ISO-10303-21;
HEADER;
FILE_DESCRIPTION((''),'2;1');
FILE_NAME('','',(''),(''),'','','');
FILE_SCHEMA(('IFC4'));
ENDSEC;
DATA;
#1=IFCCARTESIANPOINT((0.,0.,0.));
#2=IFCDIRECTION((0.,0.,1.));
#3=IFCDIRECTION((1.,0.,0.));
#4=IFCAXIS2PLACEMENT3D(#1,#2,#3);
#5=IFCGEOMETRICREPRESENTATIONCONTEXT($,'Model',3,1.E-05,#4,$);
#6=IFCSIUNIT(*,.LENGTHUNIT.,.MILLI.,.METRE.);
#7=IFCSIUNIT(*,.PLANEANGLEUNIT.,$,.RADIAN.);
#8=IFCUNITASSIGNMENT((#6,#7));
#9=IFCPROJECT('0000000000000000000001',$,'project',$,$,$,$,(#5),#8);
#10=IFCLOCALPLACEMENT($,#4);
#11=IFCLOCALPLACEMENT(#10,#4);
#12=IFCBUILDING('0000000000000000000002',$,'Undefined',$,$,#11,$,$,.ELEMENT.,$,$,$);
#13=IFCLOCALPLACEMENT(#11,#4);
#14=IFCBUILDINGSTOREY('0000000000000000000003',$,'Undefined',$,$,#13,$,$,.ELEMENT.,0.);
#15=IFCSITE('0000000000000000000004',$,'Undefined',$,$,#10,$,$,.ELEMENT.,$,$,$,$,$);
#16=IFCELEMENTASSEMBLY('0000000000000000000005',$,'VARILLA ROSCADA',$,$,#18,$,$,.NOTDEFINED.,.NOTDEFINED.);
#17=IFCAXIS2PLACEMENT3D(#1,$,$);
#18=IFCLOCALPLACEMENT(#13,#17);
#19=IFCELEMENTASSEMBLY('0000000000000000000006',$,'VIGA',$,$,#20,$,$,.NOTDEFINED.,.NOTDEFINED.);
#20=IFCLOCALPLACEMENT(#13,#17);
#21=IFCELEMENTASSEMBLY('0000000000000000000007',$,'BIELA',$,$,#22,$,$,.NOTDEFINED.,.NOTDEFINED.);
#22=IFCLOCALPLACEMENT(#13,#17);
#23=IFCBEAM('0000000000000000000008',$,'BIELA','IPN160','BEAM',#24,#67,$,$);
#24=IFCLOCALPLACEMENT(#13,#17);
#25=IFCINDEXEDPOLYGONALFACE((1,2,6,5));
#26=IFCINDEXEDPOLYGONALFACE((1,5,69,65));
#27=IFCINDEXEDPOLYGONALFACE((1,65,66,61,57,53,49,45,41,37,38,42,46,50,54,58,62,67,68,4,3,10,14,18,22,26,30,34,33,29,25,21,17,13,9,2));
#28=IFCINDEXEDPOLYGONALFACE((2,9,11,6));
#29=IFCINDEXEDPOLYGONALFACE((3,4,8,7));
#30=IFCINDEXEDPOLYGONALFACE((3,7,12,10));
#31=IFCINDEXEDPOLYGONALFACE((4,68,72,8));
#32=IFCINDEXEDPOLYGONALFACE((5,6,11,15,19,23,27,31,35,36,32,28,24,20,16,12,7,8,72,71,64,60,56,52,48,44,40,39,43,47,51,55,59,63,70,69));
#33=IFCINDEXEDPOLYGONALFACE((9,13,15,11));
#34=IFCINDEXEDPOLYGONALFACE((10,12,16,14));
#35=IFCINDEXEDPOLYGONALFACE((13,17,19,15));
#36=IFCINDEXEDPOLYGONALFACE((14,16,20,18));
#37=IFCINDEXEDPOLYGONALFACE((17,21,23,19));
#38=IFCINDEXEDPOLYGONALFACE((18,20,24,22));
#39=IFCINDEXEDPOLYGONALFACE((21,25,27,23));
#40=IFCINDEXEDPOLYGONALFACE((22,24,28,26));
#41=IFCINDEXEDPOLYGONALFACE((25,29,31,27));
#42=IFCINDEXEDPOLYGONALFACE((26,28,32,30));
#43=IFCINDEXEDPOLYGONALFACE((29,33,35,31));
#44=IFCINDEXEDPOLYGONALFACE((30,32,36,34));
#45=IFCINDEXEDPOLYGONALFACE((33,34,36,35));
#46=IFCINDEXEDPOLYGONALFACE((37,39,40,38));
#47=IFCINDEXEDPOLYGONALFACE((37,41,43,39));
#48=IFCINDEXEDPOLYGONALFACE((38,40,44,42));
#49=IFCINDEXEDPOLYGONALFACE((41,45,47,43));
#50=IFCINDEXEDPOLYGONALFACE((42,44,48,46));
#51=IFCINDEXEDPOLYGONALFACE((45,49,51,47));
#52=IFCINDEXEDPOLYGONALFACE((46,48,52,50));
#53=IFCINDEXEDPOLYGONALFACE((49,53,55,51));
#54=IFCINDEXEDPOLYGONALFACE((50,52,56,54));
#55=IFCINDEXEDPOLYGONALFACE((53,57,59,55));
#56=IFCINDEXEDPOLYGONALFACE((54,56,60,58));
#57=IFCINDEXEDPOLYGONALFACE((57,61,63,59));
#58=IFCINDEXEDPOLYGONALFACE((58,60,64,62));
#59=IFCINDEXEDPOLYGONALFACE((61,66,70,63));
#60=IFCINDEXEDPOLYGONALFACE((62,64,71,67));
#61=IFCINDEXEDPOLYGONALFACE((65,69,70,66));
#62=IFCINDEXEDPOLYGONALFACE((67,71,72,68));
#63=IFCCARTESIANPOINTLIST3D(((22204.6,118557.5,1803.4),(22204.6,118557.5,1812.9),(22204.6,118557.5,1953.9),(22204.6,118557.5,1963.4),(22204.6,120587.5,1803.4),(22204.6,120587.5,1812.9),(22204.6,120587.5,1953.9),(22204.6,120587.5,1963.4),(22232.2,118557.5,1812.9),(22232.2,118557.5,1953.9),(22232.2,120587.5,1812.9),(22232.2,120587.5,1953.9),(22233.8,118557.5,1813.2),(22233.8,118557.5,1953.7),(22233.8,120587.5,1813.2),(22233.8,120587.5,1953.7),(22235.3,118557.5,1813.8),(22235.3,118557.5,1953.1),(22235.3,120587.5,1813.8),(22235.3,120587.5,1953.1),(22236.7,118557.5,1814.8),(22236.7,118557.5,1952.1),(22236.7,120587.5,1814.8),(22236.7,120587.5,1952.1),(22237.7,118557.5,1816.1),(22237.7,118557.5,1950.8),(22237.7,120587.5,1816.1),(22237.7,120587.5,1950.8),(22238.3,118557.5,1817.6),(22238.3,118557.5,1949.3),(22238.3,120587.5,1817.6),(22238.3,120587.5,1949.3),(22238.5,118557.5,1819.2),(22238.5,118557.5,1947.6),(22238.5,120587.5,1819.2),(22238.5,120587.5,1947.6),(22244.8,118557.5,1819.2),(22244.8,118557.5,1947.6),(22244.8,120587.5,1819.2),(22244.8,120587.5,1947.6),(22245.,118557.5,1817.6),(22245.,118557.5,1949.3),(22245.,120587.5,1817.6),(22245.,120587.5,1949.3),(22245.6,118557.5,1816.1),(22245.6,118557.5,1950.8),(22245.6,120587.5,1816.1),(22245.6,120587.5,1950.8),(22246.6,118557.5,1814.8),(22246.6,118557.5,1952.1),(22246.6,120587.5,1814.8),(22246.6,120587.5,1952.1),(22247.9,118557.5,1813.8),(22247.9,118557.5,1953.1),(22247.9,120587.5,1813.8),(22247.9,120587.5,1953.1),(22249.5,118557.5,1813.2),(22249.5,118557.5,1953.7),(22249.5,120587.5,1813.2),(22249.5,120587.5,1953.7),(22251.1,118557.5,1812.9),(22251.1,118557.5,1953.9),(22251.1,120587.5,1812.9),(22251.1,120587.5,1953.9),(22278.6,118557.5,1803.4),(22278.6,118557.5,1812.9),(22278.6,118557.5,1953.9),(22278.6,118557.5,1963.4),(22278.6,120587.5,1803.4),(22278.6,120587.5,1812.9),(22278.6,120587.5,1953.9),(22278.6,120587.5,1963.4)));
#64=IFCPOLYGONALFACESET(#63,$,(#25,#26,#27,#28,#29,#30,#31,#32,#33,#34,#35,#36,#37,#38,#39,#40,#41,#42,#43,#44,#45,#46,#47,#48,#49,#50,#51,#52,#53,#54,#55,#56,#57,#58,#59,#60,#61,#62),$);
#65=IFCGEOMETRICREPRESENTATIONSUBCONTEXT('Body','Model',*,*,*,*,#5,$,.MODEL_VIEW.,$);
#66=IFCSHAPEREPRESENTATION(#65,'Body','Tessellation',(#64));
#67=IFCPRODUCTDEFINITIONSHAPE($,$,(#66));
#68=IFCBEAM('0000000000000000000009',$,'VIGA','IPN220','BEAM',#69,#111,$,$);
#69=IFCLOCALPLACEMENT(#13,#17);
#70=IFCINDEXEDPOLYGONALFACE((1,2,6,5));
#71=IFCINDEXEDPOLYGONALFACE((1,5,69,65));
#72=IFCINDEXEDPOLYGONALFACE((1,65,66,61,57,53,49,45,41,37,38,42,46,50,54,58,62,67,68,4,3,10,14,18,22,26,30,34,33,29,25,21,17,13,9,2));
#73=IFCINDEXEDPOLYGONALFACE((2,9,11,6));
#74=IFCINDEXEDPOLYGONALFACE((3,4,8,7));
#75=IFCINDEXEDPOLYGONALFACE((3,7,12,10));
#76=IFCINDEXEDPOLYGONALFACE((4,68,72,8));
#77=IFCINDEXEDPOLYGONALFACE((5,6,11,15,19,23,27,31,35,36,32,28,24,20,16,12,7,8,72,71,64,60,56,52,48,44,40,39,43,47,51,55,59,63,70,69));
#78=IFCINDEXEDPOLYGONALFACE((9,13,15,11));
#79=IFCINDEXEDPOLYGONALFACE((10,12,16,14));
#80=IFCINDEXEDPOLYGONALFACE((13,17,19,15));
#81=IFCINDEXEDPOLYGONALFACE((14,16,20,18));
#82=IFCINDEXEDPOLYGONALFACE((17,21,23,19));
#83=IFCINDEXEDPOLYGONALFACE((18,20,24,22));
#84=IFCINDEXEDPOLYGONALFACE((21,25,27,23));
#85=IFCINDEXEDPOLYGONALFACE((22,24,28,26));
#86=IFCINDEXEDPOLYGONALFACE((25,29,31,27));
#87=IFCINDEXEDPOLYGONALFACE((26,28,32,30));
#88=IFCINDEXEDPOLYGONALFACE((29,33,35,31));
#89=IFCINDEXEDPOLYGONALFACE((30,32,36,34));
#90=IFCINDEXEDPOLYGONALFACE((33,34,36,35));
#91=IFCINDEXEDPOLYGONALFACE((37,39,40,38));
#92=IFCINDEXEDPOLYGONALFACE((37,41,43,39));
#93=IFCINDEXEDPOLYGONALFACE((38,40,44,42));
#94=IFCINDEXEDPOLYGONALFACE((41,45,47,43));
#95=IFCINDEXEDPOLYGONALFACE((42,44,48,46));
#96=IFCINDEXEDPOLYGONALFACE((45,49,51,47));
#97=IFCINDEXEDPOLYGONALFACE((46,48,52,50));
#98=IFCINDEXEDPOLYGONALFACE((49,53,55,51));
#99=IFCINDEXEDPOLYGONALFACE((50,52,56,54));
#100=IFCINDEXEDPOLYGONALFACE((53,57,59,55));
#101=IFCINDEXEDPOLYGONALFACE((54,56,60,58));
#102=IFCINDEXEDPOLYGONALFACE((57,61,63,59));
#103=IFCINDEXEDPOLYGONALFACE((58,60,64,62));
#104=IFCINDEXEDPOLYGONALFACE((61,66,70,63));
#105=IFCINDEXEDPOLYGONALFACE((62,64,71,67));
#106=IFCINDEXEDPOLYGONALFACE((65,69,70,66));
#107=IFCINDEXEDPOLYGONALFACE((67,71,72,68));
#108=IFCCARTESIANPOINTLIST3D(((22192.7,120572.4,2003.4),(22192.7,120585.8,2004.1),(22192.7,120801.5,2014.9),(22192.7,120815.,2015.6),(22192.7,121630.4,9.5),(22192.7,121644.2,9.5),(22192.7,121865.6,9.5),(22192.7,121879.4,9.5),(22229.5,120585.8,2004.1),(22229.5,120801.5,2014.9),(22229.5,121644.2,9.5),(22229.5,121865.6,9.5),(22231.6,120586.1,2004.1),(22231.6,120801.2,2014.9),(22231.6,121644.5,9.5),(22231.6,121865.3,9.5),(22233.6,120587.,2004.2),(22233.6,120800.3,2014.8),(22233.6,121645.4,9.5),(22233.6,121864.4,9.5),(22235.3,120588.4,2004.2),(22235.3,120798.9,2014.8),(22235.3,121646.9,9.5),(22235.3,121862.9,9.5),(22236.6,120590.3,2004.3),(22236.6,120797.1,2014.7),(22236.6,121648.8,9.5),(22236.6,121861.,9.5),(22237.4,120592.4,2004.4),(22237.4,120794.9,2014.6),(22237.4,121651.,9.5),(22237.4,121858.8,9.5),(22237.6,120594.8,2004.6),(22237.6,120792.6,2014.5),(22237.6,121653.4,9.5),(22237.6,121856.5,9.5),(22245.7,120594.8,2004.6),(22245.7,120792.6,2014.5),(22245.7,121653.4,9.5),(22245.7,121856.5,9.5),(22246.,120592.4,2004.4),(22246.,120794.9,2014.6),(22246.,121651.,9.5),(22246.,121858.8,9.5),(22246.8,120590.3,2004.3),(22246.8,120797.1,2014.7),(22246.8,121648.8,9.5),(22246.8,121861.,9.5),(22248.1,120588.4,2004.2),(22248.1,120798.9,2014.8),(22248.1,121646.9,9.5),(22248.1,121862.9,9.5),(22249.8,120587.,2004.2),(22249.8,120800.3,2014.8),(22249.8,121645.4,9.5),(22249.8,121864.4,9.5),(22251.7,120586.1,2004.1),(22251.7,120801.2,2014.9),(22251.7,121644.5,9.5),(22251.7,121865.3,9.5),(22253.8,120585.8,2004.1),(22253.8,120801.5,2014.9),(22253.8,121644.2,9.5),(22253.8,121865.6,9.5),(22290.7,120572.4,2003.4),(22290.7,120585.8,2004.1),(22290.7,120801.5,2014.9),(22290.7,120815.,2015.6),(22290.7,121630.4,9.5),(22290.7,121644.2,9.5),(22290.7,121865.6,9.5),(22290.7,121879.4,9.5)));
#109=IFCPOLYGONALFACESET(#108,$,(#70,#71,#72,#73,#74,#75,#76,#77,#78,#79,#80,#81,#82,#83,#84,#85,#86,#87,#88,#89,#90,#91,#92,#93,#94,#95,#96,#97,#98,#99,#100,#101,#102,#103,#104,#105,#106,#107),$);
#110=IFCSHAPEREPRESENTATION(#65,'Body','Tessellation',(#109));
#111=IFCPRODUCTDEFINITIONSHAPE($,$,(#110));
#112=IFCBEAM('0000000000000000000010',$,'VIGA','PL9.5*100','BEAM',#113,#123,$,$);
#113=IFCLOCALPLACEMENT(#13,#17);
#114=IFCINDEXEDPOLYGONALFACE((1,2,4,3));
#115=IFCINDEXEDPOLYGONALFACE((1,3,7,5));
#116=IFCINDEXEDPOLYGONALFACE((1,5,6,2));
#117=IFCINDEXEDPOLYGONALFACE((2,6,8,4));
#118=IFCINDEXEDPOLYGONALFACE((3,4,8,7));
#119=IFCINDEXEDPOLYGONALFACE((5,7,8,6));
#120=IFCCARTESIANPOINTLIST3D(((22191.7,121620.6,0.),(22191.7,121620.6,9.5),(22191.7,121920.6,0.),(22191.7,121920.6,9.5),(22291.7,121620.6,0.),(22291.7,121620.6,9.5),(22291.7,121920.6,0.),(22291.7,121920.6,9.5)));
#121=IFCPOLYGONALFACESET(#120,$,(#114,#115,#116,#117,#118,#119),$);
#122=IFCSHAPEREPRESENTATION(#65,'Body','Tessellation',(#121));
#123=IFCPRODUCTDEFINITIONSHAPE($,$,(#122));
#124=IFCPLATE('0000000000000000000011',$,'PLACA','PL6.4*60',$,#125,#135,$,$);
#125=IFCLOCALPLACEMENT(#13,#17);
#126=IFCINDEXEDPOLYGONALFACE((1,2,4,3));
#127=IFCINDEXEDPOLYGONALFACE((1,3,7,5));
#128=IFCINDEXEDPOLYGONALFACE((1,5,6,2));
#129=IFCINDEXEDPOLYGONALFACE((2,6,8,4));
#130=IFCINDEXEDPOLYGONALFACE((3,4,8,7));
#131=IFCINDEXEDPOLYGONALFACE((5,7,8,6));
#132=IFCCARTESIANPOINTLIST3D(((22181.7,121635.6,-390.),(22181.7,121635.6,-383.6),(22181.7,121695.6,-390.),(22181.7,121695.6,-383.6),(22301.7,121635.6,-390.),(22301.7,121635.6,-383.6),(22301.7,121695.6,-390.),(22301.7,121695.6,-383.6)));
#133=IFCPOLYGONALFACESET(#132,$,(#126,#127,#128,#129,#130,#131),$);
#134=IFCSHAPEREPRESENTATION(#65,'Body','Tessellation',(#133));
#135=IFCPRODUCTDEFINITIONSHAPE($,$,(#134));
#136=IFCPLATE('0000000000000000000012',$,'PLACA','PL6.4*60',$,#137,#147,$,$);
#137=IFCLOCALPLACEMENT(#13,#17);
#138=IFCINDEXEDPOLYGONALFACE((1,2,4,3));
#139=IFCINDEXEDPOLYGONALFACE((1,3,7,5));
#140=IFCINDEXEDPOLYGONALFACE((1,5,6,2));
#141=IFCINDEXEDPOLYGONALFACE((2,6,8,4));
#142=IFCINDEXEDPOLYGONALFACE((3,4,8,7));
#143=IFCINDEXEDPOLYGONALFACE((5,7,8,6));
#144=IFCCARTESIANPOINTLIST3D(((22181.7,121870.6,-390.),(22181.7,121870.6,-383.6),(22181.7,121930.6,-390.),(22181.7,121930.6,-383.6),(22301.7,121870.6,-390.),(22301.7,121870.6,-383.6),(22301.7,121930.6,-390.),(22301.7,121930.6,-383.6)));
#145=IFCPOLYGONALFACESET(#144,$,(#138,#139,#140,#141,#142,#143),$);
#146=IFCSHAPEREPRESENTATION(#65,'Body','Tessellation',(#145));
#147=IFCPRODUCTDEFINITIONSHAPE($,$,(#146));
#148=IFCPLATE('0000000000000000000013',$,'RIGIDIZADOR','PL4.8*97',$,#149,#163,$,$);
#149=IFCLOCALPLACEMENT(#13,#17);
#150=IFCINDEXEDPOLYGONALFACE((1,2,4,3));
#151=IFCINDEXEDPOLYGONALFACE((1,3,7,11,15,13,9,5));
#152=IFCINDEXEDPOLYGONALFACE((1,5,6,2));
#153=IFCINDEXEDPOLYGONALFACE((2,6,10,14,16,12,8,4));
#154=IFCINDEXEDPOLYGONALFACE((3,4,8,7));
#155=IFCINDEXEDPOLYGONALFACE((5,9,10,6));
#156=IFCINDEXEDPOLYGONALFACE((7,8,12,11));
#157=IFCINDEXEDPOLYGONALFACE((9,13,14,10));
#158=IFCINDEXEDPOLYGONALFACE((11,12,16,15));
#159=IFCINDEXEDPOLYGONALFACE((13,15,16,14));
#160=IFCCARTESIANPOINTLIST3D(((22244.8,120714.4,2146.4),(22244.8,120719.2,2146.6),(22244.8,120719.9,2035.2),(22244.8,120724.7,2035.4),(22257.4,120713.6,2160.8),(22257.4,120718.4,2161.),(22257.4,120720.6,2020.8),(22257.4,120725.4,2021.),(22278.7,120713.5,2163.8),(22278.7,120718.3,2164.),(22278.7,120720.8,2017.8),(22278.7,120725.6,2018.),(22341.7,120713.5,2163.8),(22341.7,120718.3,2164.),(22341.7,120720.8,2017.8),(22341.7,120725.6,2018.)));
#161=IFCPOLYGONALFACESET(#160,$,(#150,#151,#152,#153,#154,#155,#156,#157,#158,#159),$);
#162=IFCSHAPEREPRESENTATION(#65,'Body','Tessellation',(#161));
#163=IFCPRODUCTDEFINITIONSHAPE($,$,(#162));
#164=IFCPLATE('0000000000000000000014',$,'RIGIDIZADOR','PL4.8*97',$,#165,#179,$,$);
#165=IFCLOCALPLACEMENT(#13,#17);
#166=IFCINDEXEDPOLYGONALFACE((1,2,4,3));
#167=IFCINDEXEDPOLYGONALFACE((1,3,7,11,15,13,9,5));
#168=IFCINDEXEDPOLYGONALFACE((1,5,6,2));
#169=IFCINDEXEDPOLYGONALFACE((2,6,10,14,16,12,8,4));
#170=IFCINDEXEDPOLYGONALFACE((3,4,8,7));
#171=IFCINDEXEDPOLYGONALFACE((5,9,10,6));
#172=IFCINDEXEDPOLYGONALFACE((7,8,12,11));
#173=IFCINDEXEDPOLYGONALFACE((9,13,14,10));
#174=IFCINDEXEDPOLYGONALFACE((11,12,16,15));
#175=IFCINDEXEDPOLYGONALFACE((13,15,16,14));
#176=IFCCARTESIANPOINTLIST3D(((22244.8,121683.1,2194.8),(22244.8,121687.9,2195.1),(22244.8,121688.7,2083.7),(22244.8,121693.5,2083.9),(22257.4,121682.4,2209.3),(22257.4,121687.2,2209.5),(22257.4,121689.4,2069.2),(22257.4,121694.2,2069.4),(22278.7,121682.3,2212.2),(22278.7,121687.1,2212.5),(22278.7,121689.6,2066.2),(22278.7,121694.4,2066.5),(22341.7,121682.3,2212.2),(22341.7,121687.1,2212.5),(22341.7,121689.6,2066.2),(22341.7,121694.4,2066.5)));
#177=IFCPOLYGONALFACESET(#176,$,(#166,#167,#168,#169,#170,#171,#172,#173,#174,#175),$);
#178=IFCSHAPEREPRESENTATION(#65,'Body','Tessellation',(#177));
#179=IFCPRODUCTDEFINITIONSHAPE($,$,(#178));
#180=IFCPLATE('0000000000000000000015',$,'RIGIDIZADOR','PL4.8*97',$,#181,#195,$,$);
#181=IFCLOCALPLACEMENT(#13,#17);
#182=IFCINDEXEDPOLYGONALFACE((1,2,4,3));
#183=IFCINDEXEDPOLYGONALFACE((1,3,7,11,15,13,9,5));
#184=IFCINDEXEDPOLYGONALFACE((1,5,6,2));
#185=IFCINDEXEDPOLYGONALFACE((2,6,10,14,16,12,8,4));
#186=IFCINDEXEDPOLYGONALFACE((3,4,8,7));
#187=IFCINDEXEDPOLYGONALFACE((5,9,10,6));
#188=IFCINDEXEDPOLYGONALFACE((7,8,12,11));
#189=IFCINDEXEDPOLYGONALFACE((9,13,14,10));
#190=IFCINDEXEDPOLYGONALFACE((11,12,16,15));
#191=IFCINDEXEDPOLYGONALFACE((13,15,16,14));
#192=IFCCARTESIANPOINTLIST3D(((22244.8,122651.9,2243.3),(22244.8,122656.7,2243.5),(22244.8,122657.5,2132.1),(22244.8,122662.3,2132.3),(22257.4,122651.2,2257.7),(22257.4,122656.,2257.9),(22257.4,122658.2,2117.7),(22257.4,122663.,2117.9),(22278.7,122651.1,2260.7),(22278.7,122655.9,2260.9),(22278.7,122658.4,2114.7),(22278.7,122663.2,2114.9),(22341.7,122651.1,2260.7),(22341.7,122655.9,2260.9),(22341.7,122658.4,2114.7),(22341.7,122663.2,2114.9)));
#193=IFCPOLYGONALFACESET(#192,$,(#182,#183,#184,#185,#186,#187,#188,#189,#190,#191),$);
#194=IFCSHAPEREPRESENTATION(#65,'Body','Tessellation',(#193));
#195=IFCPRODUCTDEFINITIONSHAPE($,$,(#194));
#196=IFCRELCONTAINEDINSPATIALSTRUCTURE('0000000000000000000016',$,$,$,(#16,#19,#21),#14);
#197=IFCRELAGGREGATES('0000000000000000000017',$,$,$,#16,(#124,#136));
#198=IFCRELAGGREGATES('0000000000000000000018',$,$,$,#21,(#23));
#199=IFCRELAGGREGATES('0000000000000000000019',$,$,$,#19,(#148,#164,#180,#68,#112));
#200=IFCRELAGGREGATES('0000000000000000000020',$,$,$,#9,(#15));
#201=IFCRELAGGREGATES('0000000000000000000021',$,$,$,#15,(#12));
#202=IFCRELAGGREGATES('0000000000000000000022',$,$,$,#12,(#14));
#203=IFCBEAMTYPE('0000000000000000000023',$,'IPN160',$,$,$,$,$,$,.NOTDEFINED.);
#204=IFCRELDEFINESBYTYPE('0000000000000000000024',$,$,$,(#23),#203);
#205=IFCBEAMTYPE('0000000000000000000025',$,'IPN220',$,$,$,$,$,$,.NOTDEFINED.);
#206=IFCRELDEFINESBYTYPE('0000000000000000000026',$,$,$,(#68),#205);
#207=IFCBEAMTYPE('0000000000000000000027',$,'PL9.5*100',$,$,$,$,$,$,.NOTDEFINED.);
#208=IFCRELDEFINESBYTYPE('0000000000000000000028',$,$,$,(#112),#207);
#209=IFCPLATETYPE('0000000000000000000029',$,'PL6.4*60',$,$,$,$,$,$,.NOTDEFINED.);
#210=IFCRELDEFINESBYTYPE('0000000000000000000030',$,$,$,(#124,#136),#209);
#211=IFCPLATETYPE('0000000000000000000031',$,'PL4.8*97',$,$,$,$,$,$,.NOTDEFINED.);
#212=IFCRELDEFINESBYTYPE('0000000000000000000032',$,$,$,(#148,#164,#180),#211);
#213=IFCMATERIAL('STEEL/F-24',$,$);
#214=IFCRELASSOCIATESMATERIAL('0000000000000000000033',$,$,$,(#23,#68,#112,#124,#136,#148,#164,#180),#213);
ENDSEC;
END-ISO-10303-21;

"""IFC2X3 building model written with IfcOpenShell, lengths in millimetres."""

from ifc_helpers import new_model, si_unit, frame, origin_with_axes, origin_2d_with_axis, place, context, subcontext, project, spatial, polyline, rectangle, i_section, outline, extrude, clip, halfspace, material, type_object, element, aggregate, save


model = new_model("IFC2X3")

# Units and contexts
model_context = context("Model", 3, precision=1e-05, world=origin_with_axes())
body_context = subcontext(model_context, "Body", "Model", "MODEL_VIEW")
ifc_project = project(units=[si_unit("LENGTHUNIT", "METRE", prefix="MILLI"), si_unit("PLANEANGLEUNIT", "RADIAN")], contexts=[model_context])

# Site, building, storey
site_placement = place(None, origin_with_axes())
site = spatial("IfcSite", under=ifc_project, at=site_placement, Name="Undefined", CompositionType="ELEMENT")
building_placement = place(site_placement, origin_with_axes())
building = spatial("IfcBuilding", under=site, at=building_placement, Name="Undefined", CompositionType="ELEMENT")
storey_placement = place(building_placement, origin_with_axes())
storey = spatial("IfcBuildingStorey", under=building, at=storey_placement, Name="Undefined", CompositionType="ELEMENT", Elevation=0.0)

# Element assembly
assembly_1_placement = place(storey_placement, origin_with_axes())
assembly_1 = element("IfcElementAssembly", 1, at=assembly_1_placement, inside=storey, Name="VARILLA ROSCADA", AssemblyPlace="NOTDEFINED", PredefinedType="NOTDEFINED")

# Element assembly
assembly_2_placement = place(storey_placement, origin_with_axes())
assembly_2 = element("IfcElementAssembly", 2, at=assembly_2_placement, inside=storey, Name="VIGA", AssemblyPlace="NOTDEFINED", PredefinedType="NOTDEFINED")
ifc_material_1 = material(Name="STEEL/F-24")
beam_type_1 = type_object("IfcBeamType", Name="IPN160", PredefinedType="NOTDEFINED")

# Element assembly, beam
assembly_3_placement = place(storey_placement, origin_with_axes())
assembly_3 = element("IfcElementAssembly", 3, at=assembly_3_placement, inside=storey, Name="BIELA", AssemblyPlace="NOTDEFINED", PredefinedType="NOTDEFINED")
beam_1_placement = place(assembly_3_placement, frame((22241.6, 120587.5, 1883.4), z_axis=(0.0, 0.000002, 1.0), x_axis=(0.0, -1.0, 0.000002)))
beam_1 = element("IfcBeam", 4, at=beam_1_placement, type_object=beam_type_1, material=ifc_material_1, Name="BIELA", Description="IPN160", ObjectType="BEAM", context=body_context, shape_type="SweptSolid", body=[
    extrude(i_section(OverallWidth=74.0, OverallDepth=160.0, WebThickness=6.3, FlangeThickness=9.5, FilletRadius=6.3, at=origin_2d_with_axis()), frame((2030.0, 0.0, 0.0), z_axis=(-1.0, 0.0, 0.0), x_axis=(0.0, -1.0, 0.0)), (0.0, 0.0, 1.0), 2030.0),
])

# Beams
beam_type_2 = type_object("IfcBeamType", Name="IPN220", PredefinedType="NOTDEFINED")
beam_2_placement = place(assembly_2_placement, frame((22241.7, 121754.9, 9.5), z_axis=(0.0, -0.88335, -0.468715), x_axis=(0.0, -0.468715, 0.88335)))
beam_2 = element("IfcBeam", 5, at=beam_2_placement, type_object=beam_type_2, material=ifc_material_1, Name="VIGA", Description="IPN220", ObjectType="BEAM", context=body_context, shape_type="Clipping", body=[
    clip(clip(extrude(i_section(OverallWidth=98.0, OverallDepth=220.0, WebThickness=8.1, FlangeThickness=12.2, FilletRadius=8.1, at=origin_2d_with_axis()), frame((2385.9, 0.0, 0.0), z_axis=(-1.0, 0.0, 0.0), x_axis=(0.0, -1.0, 0.0)), (0.0, 0.0, 1.0), 2507.7), halfspace(frame((2264.1, 0.0, 0.0), z_axis=(-0.905659, 0.0, 0.424006), x_axis=(0.0, 1.0, 0.0)), True)), halfspace(frame((0.0, 0.0, 0.0), z_axis=(-0.88335, 0.0, 0.468715), x_axis=(0.0, -1.0, 0.0)), False)),
])
beam_type_3 = type_object("IfcBeamType", Name="PL9.5*100", PredefinedType="NOTDEFINED")
beam_3_placement = place(assembly_2_placement, frame((22241.7, 121620.6, 4.7), z_axis=(1.0, 0.0, 0.0), x_axis=(0.0, 1.0, 0.0)))
beam_3 = element("IfcBeam", 6, at=beam_3_placement, type_object=beam_type_3, material=ifc_material_1, Name="VIGA", Description="PL9.5*100", ObjectType="BEAM", context=body_context, shape_type="SweptSolid", body=[
    extrude(rectangle(XDim=9.5, YDim=100.0, at=origin_2d_with_axis()), frame((300.0, 0.0, 0.0), z_axis=(-1.0, 0.0, 0.0), x_axis=(0.0, -1.0, 0.0)), (0.0, 0.0, 1.0), 300.0),
])

# Plates
plate_type_1 = type_object("IfcPlateType", Name="PL6.4*60", PredefinedType="NOTDEFINED")
plate_1_placement = place(assembly_1_placement, frame((22181.7, 121635.6, -386.8), z_axis=(0.0, 0.0, 1.0), x_axis=(1.0, 0.0, 0.0)))
plate_1 = element("IfcPlate", 7, at=plate_1_placement, type_object=plate_type_1, material=ifc_material_1, Name="PLACA", Description="PL6.4*60", context=body_context, shape_type="SweptSolid", body=[
    extrude(outline(polyline([(0.0, 0.0), (120.0, 0.0), (120.0, 60.0), (0.0, 60.0), (0.0, 0.0)])), frame((0.0, 0.0, -3.2), z_axis=(0.0, 0.0, 1.0), x_axis=(1.0, 0.0, 0.0)), (0.0, 0.0, 1.0), 6.4),
])
plate_2_placement = place(assembly_1_placement, frame((22181.7, 121870.6, -386.8), z_axis=(0.0, 0.0, 1.0), x_axis=(1.0, 0.0, 0.0)))
plate_2 = element("IfcPlate", 8, at=plate_2_placement, type_object=plate_type_1, material=ifc_material_1, Name="PLACA", Description="PL6.4*60", context=body_context, shape_type="SweptSolid", body=[
    extrude(outline(polyline([(0.0, 0.0), (120.0, 0.0), (120.0, 60.0), (0.0, 60.0), (0.0, 0.0)])), frame((0.0, 0.0, -3.2), z_axis=(0.0, 0.0, 1.0), x_axis=(1.0, 0.0, 0.0)), (0.0, 0.0, 1.0), 6.4),
])
plate_type_2 = type_object("IfcPlateType", Name="PL4.8*97", PredefinedType="NOTDEFINED")
plate_3_placement = place(assembly_2_placement, frame((22341.7, 120715.9, 2163.9), z_axis=(0.0, -0.998752, -0.04995), x_axis=(-1.0, 0.0, 0.0)))
plate_3 = element("IfcPlate", 9, at=plate_3_placement, type_object=plate_type_2, material=ifc_material_1, Name="RIGIDIZADOR", Description="PL4.8*97", context=body_context, shape_type="SweptSolid", body=[
    extrude(outline(polyline([(0.0, 0.0), (63.0, 0.0), (84.3, 3.0), (96.8, 17.4), (96.8, 128.7), (84.3, 143.2), (63.0, 146.2), (0.0, 146.2), (0.0, 0.0)])), frame((0.0, 0.0, -2.4), z_axis=(0.0, 0.0, 1.0), x_axis=(1.0, 0.0, 0.0)), (0.0, 0.0, 1.0), 4.8),
])
plate_4_placement = place(assembly_2_placement, frame((22341.7, 121684.7, 2212.4), z_axis=(0.0, -0.998752, -0.04995), x_axis=(-1.0, 0.0, 0.0)))
plate_4 = element("IfcPlate", 10, at=plate_4_placement, type_object=plate_type_2, material=ifc_material_1, Name="RIGIDIZADOR", Description="PL4.8*97", context=body_context, shape_type="SweptSolid", body=[
    extrude(outline(polyline([(0.0, 0.0), (63.0, 0.0), (84.3, 3.0), (96.8, 17.4), (96.8, 128.7), (84.3, 143.2), (63.0, 146.2), (0.0, 146.2), (0.0, 0.0)])), frame((0.0, 0.0, -2.4), z_axis=(0.0, 0.0, 1.0), x_axis=(1.0, 0.0, 0.0)), (0.0, 0.0, 1.0), 4.8),
])
plate_5_placement = place(assembly_2_placement, frame((22341.7, 122653.5, 2260.8), z_axis=(0.0, -0.998752, -0.04995), x_axis=(-1.0, 0.0, 0.0)))
plate_5 = element("IfcPlate", 11, at=plate_5_placement, type_object=plate_type_2, material=ifc_material_1, Name="RIGIDIZADOR", Description="PL4.8*97", context=body_context, shape_type="SweptSolid", body=[
    extrude(outline(polyline([(0.0, 0.0), (63.0, 0.0), (84.3, 3.0), (96.8, 17.4), (96.8, 128.7), (84.3, 143.2), (63.0, 146.2), (0.0, 146.2), (0.0, 0.0)])), frame((0.0, 0.0, -2.4), z_axis=(0.0, 0.0, 1.0), x_axis=(1.0, 0.0, 0.0)), (0.0, 0.0, 1.0), 4.8),
])

aggregate(assembly_1, [plate_1, plate_2])
aggregate(assembly_3, [beam_1])
aggregate(assembly_2, [plate_3, plate_4, plate_5, beam_2, beam_3])

save(model, "model.ifc")
